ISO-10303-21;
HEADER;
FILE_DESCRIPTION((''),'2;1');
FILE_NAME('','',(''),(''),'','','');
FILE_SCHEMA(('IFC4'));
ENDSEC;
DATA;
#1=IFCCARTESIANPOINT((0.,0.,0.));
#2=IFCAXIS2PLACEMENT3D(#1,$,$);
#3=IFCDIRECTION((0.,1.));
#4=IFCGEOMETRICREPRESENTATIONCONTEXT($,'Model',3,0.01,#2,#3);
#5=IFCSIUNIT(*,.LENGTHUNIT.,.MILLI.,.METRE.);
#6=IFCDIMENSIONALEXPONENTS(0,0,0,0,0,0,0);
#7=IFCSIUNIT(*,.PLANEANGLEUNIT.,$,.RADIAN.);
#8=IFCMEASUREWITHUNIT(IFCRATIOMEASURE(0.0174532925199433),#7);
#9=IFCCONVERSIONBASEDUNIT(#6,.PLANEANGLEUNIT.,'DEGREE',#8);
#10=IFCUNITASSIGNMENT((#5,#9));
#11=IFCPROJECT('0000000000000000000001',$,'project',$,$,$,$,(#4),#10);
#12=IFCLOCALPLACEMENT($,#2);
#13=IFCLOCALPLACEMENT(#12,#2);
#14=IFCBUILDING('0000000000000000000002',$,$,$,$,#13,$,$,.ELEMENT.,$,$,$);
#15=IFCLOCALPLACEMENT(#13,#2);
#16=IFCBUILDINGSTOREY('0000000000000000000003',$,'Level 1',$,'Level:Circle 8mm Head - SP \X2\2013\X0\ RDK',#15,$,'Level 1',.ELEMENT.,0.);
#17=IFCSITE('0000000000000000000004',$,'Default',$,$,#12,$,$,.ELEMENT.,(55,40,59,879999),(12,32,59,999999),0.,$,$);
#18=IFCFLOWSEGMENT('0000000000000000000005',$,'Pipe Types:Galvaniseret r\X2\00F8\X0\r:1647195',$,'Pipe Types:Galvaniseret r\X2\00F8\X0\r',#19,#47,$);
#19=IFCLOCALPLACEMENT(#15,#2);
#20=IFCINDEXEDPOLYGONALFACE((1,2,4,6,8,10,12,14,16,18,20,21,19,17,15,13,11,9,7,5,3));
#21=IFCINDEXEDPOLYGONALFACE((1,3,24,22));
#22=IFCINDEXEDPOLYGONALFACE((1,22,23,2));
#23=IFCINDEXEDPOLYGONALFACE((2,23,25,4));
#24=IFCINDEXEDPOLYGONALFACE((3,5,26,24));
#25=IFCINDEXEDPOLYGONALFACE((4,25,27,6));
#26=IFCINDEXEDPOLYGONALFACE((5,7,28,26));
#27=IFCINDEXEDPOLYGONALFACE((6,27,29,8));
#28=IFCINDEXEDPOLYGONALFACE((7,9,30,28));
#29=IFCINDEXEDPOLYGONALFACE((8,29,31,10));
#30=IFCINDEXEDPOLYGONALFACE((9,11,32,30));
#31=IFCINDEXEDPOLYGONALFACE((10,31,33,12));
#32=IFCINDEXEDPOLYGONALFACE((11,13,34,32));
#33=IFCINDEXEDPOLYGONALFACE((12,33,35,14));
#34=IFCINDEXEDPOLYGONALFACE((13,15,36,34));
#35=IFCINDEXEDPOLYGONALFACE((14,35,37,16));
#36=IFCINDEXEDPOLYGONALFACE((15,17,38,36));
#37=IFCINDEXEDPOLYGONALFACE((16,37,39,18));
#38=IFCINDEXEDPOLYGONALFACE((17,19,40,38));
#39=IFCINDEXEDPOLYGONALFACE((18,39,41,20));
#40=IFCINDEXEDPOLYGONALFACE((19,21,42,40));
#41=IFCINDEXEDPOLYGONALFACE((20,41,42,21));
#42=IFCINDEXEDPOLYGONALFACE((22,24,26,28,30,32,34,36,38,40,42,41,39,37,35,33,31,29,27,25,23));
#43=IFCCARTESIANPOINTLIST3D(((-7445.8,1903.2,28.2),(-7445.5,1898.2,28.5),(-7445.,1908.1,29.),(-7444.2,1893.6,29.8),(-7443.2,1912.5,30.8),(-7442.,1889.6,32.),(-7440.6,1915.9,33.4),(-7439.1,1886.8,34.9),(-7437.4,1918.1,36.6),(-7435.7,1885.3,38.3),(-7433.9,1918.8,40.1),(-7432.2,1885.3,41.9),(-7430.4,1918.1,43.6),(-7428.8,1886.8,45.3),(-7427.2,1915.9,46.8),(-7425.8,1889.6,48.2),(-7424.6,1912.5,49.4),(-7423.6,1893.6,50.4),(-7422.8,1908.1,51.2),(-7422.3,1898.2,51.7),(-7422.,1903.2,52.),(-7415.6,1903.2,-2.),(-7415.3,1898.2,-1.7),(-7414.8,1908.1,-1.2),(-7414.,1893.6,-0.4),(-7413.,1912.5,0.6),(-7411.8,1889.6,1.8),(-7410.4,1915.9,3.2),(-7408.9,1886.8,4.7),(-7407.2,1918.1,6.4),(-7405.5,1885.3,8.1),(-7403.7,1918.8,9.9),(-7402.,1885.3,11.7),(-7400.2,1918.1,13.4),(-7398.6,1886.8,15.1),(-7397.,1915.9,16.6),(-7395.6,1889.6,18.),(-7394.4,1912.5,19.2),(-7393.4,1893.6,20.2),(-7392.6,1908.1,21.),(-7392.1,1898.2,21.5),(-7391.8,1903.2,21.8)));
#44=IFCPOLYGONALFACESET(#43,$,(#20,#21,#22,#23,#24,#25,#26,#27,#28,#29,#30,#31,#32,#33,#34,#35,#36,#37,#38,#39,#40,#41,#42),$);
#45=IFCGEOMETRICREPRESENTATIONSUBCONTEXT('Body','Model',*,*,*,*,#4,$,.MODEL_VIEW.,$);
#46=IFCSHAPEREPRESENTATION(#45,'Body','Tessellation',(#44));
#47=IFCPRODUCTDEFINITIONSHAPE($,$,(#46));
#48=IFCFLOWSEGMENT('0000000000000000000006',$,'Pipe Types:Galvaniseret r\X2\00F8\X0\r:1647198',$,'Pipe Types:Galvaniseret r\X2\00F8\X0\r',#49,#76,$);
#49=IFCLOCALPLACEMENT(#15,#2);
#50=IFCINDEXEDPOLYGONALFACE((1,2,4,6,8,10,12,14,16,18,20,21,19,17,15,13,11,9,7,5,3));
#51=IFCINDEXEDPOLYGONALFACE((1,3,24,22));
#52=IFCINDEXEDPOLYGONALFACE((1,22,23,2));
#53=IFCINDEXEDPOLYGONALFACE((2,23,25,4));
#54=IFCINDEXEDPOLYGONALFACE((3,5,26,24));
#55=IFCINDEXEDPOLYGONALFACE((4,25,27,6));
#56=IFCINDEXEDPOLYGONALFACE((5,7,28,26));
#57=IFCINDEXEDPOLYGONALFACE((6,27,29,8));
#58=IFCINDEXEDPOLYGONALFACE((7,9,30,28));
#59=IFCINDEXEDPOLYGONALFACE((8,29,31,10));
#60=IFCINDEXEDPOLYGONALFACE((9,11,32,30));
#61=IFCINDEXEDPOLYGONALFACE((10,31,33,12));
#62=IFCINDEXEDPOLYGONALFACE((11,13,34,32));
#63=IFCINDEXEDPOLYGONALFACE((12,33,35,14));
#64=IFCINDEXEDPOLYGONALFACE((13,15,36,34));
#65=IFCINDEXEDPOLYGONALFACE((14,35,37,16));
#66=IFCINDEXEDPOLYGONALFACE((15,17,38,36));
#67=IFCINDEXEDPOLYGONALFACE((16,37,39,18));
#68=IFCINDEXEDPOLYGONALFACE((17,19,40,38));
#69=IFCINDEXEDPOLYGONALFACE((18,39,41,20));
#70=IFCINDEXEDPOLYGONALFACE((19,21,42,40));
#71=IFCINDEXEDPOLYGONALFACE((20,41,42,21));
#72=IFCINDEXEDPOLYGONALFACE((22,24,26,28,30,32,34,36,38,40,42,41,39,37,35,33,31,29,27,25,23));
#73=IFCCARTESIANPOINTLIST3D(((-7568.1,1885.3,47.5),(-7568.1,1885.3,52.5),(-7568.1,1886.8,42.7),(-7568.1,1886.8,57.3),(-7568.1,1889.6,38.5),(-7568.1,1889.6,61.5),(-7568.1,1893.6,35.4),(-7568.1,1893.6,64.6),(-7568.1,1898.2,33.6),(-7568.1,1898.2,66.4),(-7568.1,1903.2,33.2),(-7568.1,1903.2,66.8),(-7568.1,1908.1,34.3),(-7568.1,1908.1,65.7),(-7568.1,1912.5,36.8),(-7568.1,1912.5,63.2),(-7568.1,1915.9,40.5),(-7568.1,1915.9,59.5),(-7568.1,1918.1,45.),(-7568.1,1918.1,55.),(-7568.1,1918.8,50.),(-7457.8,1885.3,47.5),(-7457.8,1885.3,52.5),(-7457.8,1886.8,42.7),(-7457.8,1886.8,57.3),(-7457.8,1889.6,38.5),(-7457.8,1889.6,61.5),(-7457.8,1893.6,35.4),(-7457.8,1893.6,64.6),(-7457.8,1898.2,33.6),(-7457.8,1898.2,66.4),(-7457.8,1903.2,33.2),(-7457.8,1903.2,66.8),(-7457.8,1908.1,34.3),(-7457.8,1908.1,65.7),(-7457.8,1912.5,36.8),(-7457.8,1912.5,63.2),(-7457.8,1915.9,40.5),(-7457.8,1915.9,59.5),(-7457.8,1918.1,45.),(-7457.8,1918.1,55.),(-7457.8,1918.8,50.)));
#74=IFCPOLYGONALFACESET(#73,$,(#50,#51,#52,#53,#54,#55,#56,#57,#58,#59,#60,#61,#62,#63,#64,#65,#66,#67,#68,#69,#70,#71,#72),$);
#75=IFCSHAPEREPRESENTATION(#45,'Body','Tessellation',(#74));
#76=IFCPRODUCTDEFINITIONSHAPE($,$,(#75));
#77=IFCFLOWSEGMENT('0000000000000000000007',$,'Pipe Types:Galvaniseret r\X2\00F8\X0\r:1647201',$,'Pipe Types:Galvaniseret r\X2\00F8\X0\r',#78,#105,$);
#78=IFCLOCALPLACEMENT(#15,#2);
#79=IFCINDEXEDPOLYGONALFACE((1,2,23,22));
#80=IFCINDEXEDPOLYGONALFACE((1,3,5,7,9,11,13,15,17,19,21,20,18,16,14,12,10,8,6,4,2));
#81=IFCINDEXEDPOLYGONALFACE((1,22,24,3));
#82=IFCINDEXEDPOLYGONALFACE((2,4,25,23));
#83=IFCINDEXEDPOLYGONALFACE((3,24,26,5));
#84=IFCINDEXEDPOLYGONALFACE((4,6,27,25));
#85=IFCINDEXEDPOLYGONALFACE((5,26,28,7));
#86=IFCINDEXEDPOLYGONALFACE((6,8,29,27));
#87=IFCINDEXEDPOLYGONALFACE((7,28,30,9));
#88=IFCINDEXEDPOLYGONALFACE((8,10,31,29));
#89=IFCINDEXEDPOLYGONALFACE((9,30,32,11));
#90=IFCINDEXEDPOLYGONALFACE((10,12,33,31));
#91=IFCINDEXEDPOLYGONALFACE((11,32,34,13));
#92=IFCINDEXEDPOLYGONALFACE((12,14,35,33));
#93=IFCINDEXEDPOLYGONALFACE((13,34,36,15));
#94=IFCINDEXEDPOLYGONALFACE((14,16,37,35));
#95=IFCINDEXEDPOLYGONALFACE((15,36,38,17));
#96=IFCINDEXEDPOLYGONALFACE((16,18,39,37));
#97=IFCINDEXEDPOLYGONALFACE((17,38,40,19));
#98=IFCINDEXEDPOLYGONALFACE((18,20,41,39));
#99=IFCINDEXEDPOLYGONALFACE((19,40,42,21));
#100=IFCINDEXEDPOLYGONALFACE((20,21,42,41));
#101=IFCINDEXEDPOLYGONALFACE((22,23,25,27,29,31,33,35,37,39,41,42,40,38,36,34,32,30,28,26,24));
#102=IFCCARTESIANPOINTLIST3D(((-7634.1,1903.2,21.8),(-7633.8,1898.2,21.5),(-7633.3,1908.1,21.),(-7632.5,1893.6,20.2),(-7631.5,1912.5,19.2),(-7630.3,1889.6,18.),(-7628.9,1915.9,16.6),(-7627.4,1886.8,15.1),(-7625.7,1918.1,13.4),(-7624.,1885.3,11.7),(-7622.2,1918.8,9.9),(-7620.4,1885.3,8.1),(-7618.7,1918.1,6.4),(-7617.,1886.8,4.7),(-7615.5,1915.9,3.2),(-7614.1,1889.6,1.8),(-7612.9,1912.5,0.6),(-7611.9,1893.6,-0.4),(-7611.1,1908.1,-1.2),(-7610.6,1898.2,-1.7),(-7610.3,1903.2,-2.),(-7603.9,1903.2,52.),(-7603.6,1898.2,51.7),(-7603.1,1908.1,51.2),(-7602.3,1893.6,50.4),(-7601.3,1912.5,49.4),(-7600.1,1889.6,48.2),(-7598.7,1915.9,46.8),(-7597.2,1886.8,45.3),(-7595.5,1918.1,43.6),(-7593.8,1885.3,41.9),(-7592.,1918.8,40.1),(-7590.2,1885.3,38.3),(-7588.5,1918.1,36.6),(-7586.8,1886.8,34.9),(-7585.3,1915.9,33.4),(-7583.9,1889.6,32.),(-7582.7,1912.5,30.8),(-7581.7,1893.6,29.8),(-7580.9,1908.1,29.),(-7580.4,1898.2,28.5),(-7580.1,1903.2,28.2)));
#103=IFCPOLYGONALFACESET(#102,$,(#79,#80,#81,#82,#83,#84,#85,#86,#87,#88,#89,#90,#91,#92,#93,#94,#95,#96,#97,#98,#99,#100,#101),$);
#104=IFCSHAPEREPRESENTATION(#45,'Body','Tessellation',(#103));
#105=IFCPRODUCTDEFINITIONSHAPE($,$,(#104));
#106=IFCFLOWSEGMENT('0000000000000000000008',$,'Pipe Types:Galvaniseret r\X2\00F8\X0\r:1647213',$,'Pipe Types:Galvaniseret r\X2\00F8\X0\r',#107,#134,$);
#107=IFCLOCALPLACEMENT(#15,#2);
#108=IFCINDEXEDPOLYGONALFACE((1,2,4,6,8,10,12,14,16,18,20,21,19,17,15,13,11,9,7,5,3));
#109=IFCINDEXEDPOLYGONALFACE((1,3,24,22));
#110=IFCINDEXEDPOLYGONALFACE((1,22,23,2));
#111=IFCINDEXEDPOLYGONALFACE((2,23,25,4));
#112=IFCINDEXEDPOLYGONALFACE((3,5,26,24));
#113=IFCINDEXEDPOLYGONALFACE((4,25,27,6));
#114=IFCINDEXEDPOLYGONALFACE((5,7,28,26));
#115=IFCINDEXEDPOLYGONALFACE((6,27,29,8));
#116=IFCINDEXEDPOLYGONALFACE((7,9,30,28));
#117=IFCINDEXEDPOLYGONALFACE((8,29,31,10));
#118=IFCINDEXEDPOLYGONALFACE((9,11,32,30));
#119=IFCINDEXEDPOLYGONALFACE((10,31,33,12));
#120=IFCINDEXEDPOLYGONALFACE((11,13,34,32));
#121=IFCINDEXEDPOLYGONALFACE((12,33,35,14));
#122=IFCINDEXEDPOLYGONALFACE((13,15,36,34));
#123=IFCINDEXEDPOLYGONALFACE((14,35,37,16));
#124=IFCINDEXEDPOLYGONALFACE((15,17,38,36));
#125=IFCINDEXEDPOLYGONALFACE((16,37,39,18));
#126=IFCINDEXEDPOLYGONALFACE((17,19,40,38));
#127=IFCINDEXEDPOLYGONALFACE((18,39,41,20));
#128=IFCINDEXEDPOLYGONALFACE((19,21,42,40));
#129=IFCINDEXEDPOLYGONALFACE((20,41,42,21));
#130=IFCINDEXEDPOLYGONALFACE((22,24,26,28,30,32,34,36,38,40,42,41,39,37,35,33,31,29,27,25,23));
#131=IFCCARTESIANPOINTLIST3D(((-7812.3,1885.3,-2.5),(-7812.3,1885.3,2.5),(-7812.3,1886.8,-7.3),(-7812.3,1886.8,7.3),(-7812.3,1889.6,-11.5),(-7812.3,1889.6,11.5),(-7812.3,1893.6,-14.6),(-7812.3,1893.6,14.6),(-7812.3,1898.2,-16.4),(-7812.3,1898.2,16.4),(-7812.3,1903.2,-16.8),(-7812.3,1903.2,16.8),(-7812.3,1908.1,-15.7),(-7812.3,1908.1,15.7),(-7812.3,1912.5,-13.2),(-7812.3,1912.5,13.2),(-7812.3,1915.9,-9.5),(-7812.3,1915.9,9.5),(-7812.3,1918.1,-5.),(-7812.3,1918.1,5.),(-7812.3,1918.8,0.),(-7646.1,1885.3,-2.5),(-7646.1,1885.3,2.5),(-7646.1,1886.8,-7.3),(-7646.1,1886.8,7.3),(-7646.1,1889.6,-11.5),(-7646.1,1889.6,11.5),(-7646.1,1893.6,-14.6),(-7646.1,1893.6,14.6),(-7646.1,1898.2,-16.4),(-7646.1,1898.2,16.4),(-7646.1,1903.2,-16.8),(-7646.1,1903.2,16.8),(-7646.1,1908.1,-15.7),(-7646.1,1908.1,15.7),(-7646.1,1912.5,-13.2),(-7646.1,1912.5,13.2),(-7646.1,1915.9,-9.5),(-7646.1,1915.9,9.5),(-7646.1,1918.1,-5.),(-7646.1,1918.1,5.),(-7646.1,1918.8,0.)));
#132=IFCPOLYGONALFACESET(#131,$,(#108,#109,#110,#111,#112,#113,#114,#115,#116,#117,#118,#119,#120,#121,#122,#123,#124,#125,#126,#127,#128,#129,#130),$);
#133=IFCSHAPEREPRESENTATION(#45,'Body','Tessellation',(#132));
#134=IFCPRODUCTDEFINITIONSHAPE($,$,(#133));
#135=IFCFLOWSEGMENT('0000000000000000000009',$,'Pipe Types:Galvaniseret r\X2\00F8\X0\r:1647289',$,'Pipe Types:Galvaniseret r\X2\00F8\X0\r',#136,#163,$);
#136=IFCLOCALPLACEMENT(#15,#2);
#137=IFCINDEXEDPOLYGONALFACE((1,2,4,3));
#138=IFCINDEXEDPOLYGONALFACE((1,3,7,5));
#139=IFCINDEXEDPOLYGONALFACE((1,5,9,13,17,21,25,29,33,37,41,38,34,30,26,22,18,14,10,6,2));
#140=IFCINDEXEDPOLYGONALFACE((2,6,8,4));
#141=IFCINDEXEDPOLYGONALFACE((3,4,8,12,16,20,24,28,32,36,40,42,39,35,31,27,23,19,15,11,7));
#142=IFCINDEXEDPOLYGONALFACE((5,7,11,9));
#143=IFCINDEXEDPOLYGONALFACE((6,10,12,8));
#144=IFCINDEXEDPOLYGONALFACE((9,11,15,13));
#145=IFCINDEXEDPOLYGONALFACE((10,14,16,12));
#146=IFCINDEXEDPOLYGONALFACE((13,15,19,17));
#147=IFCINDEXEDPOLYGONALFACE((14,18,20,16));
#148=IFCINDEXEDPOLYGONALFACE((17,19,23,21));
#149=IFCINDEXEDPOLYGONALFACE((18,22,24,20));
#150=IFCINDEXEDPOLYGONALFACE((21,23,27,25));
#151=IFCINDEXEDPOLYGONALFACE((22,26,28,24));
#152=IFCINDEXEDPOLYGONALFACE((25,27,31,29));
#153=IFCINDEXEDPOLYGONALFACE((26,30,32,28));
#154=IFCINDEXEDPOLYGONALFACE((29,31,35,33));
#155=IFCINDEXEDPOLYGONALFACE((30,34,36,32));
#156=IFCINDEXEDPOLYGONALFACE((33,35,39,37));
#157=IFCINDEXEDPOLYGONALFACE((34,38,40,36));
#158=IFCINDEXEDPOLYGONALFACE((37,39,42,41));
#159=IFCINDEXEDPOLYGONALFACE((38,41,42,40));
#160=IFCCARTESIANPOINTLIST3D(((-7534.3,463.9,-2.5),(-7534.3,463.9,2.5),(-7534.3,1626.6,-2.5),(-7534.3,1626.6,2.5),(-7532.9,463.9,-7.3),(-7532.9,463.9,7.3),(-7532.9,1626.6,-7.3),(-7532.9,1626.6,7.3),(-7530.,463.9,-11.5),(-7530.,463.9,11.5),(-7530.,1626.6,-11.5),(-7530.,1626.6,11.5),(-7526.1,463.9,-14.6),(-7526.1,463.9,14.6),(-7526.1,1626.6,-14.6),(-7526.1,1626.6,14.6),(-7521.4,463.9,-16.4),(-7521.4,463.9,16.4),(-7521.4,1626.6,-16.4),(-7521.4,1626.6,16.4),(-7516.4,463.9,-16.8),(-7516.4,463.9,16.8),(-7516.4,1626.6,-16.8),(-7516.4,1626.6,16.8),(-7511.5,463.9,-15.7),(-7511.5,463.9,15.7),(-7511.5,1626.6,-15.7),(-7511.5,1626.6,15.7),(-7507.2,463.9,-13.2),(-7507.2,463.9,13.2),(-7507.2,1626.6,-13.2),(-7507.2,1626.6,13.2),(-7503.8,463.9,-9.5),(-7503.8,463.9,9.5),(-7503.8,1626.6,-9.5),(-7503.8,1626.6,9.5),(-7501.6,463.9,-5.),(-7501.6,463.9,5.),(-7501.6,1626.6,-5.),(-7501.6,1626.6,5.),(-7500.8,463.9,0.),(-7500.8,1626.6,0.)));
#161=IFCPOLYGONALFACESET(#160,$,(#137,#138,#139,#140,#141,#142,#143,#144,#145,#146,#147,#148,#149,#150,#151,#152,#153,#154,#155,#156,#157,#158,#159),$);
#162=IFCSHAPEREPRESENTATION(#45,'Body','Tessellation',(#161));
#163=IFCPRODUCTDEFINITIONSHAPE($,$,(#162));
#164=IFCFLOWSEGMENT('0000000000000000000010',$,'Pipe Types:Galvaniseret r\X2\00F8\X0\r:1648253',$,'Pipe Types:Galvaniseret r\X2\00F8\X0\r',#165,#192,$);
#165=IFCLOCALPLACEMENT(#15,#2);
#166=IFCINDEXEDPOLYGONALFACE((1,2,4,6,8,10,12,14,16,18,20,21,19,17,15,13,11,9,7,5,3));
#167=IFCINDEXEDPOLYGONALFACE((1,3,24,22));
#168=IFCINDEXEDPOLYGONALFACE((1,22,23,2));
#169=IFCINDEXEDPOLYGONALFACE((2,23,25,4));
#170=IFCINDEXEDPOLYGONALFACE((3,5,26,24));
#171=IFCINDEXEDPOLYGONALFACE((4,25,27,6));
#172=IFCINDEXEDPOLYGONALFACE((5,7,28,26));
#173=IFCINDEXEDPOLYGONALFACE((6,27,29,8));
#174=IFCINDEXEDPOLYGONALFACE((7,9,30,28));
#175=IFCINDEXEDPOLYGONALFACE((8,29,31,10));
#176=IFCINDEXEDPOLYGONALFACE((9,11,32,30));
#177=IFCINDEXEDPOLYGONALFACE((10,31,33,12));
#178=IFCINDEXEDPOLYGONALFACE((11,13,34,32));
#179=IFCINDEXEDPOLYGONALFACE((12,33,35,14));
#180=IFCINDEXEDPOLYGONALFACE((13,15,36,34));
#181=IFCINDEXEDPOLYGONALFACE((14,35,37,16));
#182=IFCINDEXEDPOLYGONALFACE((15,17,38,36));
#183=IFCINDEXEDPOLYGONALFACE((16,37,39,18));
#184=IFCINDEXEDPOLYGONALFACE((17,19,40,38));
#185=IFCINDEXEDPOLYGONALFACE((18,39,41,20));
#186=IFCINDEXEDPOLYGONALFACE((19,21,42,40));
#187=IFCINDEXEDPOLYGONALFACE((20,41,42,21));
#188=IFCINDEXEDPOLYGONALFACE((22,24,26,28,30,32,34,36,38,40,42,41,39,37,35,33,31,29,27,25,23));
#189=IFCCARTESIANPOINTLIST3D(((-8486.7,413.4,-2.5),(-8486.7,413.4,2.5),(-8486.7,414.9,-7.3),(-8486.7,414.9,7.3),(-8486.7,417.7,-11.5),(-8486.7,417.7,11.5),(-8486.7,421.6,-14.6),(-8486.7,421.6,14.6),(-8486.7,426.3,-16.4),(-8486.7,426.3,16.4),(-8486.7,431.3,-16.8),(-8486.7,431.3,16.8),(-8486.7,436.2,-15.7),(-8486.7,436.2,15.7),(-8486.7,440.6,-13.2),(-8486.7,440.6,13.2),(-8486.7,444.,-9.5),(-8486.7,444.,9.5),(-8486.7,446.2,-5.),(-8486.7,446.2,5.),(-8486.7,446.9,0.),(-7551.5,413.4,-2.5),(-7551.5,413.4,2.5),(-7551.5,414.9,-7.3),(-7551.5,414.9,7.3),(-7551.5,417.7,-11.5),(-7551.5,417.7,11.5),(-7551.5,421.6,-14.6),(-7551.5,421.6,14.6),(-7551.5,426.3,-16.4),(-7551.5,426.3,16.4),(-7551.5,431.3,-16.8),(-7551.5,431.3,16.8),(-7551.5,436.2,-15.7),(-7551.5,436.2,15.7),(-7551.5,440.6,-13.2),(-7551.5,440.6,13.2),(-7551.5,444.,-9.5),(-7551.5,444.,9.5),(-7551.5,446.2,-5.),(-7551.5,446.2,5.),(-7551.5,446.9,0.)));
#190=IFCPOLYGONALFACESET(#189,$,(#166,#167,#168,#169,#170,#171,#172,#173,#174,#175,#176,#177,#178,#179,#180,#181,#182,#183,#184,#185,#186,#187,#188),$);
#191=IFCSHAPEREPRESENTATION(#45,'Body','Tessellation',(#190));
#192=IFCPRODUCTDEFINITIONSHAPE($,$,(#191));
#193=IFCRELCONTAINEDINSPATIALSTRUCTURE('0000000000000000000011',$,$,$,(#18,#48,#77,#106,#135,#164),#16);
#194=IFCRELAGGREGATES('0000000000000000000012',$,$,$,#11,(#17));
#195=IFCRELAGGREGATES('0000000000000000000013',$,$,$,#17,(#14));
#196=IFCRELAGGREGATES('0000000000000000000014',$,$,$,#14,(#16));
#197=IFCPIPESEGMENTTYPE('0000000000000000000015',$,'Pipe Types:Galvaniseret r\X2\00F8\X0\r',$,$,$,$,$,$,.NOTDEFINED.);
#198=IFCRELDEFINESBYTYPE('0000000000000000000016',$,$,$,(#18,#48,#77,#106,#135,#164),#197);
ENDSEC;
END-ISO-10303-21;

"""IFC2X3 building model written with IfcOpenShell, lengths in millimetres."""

from ifc_helpers import new_model, entity, si_unit, converted_unit, direction, frame, frame_2d, origin, origin_2d_with_axis, place, context, subcontext, project, spatial, circle, extrude, type_object, element, save


model = new_model("IFC2X3")

# Units and contexts
model_context = context("Model", 3, precision=0.01, world=origin(), true_north=direction((0.0, 1.0)))
body_context = subcontext(model_context, "Body", "Model", "MODEL_VIEW")
ifc_project = project(units=[si_unit("LENGTHUNIT", "METRE", prefix="MILLI"), converted_unit("PLANEANGLEUNIT", "DEGREE", entity("IfcRatioMeasure", 0.0174532925199433), si_unit("PLANEANGLEUNIT", "RADIAN"), dimensions=[0, 0, 0, 0, 0, 0, 0])], contexts=[model_context])

# Site, building, storey
site_placement = place(None, origin())
site = spatial("IfcSite", under=ifc_project, at=site_placement, Name="Default", CompositionType="ELEMENT", RefLatitude=(55, 40, 59, 879999), RefLongitude=(12, 32, 59, 999999), RefElevation=0.0)
building_placement = place(site_placement, origin())
building = spatial("IfcBuilding", under=site, at=building_placement, CompositionType="ELEMENT")
storey_placement = place(building_placement, origin())
storey = spatial("IfcBuildingStorey", under=building, at=storey_placement, Name="Level 1", ObjectType="Level:Circle 8mm Head - SP – RDK", LongName="Level 1", CompositionType="ELEMENT", Elevation=0.0)

# Flow segments
pipe_segment_type = type_object("IfcPipeSegmentType", Name="Pipe Types:Galvaniseret rør", PredefinedType="NOTDEFINED")
flow_segment_1_placement = place(storey_placement, origin())
element("IfcFlowSegment", 1, at=flow_segment_1_placement, inside=storey, type_object=pipe_segment_type, Name="Pipe Types:Galvaniseret rør:1647195", ObjectType="Pipe Types:Galvaniseret rør", context=body_context, shape_type="SweptSolid", body=[
    extrude(circle(Radius=16.9, at=origin_2d_with_axis()), frame((-7433.9, 1902.0, 40.1), z_axis=(0.707107, 0.0, -0.707107), x_axis=(0.0, 1.0, 0.0)), (0.0, 0.0, 1.0), 42.7),
])
flow_segment_2_placement = place(storey_placement, origin())
element("IfcFlowSegment", 2, at=flow_segment_2_placement, inside=storey, type_object=pipe_segment_type, Name="Pipe Types:Galvaniseret rør:1647198", ObjectType="Pipe Types:Galvaniseret rør", context=body_context, shape_type="SweptSolid", body=[
    extrude(circle(Radius=16.9, at=frame_2d((0.0, 0.0), x_axis=(1.0, 0.0))), frame((-7568.1, 1902.0, 50.0), z_axis=(1.0, 0.0, 0.0), x_axis=(0.0, 1.0, 0.0)), (0.0, 0.0, 1.0), 110.3),
])
flow_segment_3_placement = place(storey_placement, origin())
element("IfcFlowSegment", 3, at=flow_segment_3_placement, inside=storey, type_object=pipe_segment_type, Name="Pipe Types:Galvaniseret rør:1647201", ObjectType="Pipe Types:Galvaniseret rør", context=body_context, shape_type="SweptSolid", body=[
    extrude(circle(Radius=16.9, at=frame_2d((0.0, 0.0), x_axis=(1.0, 0.0))), frame((-7622.2, 1902.0, 9.9), z_axis=(0.707107, 0.0, 0.707107), x_axis=(0.0, 1.0, 0.0)), (0.0, 0.0, 1.0), 42.7),
])
flow_segment_4_placement = place(storey_placement, origin())
element("IfcFlowSegment", 4, at=flow_segment_4_placement, inside=storey, type_object=pipe_segment_type, Name="Pipe Types:Galvaniseret rør:1647213", ObjectType="Pipe Types:Galvaniseret rør", context=body_context, shape_type="SweptSolid", body=[
    extrude(circle(Radius=16.9, at=frame_2d((0.0, 0.0), x_axis=(1.0, 0.0))), frame((-7812.3, 1902.0, 0.0), z_axis=(1.0, 0.0, 0.0), x_axis=(0.0, 1.0, 0.0)), (0.0, 0.0, 1.0), 166.2),
])
flow_segment_5_placement = place(storey_placement, origin())
element("IfcFlowSegment", 5, at=flow_segment_5_placement, inside=storey, type_object=pipe_segment_type, Name="Pipe Types:Galvaniseret rør:1647289", ObjectType="Pipe Types:Galvaniseret rør", context=body_context, shape_type="SweptSolid", body=[
    extrude(circle(Radius=16.9, at=frame_2d((0.0, 0.0), x_axis=(1.0, 0.0))), frame((-7517.7, 463.9, 0.0), z_axis=(0.0, 1.0, 0.0), x_axis=(1.0, 0.0, 0.0)), (0.0, 0.0, 1.0), 1162.7),
])
flow_segment_6_placement = place(storey_placement, origin())
element("IfcFlowSegment", 6, at=flow_segment_6_placement, inside=storey, type_object=pipe_segment_type, Name="Pipe Types:Galvaniseret rør:1648253", ObjectType="Pipe Types:Galvaniseret rør", context=body_context, shape_type="SweptSolid", body=[
    extrude(circle(Radius=16.9, at=frame_2d((0.0, 0.0), x_axis=(1.0, 0.0))), frame((-8486.7, 430.1, 0.0), z_axis=(1.0, 0.0, 0.0), x_axis=(0.0, 1.0, 0.0)), (0.0, 0.0, 1.0), 935.2),
])

save(model, "model.ifc")
